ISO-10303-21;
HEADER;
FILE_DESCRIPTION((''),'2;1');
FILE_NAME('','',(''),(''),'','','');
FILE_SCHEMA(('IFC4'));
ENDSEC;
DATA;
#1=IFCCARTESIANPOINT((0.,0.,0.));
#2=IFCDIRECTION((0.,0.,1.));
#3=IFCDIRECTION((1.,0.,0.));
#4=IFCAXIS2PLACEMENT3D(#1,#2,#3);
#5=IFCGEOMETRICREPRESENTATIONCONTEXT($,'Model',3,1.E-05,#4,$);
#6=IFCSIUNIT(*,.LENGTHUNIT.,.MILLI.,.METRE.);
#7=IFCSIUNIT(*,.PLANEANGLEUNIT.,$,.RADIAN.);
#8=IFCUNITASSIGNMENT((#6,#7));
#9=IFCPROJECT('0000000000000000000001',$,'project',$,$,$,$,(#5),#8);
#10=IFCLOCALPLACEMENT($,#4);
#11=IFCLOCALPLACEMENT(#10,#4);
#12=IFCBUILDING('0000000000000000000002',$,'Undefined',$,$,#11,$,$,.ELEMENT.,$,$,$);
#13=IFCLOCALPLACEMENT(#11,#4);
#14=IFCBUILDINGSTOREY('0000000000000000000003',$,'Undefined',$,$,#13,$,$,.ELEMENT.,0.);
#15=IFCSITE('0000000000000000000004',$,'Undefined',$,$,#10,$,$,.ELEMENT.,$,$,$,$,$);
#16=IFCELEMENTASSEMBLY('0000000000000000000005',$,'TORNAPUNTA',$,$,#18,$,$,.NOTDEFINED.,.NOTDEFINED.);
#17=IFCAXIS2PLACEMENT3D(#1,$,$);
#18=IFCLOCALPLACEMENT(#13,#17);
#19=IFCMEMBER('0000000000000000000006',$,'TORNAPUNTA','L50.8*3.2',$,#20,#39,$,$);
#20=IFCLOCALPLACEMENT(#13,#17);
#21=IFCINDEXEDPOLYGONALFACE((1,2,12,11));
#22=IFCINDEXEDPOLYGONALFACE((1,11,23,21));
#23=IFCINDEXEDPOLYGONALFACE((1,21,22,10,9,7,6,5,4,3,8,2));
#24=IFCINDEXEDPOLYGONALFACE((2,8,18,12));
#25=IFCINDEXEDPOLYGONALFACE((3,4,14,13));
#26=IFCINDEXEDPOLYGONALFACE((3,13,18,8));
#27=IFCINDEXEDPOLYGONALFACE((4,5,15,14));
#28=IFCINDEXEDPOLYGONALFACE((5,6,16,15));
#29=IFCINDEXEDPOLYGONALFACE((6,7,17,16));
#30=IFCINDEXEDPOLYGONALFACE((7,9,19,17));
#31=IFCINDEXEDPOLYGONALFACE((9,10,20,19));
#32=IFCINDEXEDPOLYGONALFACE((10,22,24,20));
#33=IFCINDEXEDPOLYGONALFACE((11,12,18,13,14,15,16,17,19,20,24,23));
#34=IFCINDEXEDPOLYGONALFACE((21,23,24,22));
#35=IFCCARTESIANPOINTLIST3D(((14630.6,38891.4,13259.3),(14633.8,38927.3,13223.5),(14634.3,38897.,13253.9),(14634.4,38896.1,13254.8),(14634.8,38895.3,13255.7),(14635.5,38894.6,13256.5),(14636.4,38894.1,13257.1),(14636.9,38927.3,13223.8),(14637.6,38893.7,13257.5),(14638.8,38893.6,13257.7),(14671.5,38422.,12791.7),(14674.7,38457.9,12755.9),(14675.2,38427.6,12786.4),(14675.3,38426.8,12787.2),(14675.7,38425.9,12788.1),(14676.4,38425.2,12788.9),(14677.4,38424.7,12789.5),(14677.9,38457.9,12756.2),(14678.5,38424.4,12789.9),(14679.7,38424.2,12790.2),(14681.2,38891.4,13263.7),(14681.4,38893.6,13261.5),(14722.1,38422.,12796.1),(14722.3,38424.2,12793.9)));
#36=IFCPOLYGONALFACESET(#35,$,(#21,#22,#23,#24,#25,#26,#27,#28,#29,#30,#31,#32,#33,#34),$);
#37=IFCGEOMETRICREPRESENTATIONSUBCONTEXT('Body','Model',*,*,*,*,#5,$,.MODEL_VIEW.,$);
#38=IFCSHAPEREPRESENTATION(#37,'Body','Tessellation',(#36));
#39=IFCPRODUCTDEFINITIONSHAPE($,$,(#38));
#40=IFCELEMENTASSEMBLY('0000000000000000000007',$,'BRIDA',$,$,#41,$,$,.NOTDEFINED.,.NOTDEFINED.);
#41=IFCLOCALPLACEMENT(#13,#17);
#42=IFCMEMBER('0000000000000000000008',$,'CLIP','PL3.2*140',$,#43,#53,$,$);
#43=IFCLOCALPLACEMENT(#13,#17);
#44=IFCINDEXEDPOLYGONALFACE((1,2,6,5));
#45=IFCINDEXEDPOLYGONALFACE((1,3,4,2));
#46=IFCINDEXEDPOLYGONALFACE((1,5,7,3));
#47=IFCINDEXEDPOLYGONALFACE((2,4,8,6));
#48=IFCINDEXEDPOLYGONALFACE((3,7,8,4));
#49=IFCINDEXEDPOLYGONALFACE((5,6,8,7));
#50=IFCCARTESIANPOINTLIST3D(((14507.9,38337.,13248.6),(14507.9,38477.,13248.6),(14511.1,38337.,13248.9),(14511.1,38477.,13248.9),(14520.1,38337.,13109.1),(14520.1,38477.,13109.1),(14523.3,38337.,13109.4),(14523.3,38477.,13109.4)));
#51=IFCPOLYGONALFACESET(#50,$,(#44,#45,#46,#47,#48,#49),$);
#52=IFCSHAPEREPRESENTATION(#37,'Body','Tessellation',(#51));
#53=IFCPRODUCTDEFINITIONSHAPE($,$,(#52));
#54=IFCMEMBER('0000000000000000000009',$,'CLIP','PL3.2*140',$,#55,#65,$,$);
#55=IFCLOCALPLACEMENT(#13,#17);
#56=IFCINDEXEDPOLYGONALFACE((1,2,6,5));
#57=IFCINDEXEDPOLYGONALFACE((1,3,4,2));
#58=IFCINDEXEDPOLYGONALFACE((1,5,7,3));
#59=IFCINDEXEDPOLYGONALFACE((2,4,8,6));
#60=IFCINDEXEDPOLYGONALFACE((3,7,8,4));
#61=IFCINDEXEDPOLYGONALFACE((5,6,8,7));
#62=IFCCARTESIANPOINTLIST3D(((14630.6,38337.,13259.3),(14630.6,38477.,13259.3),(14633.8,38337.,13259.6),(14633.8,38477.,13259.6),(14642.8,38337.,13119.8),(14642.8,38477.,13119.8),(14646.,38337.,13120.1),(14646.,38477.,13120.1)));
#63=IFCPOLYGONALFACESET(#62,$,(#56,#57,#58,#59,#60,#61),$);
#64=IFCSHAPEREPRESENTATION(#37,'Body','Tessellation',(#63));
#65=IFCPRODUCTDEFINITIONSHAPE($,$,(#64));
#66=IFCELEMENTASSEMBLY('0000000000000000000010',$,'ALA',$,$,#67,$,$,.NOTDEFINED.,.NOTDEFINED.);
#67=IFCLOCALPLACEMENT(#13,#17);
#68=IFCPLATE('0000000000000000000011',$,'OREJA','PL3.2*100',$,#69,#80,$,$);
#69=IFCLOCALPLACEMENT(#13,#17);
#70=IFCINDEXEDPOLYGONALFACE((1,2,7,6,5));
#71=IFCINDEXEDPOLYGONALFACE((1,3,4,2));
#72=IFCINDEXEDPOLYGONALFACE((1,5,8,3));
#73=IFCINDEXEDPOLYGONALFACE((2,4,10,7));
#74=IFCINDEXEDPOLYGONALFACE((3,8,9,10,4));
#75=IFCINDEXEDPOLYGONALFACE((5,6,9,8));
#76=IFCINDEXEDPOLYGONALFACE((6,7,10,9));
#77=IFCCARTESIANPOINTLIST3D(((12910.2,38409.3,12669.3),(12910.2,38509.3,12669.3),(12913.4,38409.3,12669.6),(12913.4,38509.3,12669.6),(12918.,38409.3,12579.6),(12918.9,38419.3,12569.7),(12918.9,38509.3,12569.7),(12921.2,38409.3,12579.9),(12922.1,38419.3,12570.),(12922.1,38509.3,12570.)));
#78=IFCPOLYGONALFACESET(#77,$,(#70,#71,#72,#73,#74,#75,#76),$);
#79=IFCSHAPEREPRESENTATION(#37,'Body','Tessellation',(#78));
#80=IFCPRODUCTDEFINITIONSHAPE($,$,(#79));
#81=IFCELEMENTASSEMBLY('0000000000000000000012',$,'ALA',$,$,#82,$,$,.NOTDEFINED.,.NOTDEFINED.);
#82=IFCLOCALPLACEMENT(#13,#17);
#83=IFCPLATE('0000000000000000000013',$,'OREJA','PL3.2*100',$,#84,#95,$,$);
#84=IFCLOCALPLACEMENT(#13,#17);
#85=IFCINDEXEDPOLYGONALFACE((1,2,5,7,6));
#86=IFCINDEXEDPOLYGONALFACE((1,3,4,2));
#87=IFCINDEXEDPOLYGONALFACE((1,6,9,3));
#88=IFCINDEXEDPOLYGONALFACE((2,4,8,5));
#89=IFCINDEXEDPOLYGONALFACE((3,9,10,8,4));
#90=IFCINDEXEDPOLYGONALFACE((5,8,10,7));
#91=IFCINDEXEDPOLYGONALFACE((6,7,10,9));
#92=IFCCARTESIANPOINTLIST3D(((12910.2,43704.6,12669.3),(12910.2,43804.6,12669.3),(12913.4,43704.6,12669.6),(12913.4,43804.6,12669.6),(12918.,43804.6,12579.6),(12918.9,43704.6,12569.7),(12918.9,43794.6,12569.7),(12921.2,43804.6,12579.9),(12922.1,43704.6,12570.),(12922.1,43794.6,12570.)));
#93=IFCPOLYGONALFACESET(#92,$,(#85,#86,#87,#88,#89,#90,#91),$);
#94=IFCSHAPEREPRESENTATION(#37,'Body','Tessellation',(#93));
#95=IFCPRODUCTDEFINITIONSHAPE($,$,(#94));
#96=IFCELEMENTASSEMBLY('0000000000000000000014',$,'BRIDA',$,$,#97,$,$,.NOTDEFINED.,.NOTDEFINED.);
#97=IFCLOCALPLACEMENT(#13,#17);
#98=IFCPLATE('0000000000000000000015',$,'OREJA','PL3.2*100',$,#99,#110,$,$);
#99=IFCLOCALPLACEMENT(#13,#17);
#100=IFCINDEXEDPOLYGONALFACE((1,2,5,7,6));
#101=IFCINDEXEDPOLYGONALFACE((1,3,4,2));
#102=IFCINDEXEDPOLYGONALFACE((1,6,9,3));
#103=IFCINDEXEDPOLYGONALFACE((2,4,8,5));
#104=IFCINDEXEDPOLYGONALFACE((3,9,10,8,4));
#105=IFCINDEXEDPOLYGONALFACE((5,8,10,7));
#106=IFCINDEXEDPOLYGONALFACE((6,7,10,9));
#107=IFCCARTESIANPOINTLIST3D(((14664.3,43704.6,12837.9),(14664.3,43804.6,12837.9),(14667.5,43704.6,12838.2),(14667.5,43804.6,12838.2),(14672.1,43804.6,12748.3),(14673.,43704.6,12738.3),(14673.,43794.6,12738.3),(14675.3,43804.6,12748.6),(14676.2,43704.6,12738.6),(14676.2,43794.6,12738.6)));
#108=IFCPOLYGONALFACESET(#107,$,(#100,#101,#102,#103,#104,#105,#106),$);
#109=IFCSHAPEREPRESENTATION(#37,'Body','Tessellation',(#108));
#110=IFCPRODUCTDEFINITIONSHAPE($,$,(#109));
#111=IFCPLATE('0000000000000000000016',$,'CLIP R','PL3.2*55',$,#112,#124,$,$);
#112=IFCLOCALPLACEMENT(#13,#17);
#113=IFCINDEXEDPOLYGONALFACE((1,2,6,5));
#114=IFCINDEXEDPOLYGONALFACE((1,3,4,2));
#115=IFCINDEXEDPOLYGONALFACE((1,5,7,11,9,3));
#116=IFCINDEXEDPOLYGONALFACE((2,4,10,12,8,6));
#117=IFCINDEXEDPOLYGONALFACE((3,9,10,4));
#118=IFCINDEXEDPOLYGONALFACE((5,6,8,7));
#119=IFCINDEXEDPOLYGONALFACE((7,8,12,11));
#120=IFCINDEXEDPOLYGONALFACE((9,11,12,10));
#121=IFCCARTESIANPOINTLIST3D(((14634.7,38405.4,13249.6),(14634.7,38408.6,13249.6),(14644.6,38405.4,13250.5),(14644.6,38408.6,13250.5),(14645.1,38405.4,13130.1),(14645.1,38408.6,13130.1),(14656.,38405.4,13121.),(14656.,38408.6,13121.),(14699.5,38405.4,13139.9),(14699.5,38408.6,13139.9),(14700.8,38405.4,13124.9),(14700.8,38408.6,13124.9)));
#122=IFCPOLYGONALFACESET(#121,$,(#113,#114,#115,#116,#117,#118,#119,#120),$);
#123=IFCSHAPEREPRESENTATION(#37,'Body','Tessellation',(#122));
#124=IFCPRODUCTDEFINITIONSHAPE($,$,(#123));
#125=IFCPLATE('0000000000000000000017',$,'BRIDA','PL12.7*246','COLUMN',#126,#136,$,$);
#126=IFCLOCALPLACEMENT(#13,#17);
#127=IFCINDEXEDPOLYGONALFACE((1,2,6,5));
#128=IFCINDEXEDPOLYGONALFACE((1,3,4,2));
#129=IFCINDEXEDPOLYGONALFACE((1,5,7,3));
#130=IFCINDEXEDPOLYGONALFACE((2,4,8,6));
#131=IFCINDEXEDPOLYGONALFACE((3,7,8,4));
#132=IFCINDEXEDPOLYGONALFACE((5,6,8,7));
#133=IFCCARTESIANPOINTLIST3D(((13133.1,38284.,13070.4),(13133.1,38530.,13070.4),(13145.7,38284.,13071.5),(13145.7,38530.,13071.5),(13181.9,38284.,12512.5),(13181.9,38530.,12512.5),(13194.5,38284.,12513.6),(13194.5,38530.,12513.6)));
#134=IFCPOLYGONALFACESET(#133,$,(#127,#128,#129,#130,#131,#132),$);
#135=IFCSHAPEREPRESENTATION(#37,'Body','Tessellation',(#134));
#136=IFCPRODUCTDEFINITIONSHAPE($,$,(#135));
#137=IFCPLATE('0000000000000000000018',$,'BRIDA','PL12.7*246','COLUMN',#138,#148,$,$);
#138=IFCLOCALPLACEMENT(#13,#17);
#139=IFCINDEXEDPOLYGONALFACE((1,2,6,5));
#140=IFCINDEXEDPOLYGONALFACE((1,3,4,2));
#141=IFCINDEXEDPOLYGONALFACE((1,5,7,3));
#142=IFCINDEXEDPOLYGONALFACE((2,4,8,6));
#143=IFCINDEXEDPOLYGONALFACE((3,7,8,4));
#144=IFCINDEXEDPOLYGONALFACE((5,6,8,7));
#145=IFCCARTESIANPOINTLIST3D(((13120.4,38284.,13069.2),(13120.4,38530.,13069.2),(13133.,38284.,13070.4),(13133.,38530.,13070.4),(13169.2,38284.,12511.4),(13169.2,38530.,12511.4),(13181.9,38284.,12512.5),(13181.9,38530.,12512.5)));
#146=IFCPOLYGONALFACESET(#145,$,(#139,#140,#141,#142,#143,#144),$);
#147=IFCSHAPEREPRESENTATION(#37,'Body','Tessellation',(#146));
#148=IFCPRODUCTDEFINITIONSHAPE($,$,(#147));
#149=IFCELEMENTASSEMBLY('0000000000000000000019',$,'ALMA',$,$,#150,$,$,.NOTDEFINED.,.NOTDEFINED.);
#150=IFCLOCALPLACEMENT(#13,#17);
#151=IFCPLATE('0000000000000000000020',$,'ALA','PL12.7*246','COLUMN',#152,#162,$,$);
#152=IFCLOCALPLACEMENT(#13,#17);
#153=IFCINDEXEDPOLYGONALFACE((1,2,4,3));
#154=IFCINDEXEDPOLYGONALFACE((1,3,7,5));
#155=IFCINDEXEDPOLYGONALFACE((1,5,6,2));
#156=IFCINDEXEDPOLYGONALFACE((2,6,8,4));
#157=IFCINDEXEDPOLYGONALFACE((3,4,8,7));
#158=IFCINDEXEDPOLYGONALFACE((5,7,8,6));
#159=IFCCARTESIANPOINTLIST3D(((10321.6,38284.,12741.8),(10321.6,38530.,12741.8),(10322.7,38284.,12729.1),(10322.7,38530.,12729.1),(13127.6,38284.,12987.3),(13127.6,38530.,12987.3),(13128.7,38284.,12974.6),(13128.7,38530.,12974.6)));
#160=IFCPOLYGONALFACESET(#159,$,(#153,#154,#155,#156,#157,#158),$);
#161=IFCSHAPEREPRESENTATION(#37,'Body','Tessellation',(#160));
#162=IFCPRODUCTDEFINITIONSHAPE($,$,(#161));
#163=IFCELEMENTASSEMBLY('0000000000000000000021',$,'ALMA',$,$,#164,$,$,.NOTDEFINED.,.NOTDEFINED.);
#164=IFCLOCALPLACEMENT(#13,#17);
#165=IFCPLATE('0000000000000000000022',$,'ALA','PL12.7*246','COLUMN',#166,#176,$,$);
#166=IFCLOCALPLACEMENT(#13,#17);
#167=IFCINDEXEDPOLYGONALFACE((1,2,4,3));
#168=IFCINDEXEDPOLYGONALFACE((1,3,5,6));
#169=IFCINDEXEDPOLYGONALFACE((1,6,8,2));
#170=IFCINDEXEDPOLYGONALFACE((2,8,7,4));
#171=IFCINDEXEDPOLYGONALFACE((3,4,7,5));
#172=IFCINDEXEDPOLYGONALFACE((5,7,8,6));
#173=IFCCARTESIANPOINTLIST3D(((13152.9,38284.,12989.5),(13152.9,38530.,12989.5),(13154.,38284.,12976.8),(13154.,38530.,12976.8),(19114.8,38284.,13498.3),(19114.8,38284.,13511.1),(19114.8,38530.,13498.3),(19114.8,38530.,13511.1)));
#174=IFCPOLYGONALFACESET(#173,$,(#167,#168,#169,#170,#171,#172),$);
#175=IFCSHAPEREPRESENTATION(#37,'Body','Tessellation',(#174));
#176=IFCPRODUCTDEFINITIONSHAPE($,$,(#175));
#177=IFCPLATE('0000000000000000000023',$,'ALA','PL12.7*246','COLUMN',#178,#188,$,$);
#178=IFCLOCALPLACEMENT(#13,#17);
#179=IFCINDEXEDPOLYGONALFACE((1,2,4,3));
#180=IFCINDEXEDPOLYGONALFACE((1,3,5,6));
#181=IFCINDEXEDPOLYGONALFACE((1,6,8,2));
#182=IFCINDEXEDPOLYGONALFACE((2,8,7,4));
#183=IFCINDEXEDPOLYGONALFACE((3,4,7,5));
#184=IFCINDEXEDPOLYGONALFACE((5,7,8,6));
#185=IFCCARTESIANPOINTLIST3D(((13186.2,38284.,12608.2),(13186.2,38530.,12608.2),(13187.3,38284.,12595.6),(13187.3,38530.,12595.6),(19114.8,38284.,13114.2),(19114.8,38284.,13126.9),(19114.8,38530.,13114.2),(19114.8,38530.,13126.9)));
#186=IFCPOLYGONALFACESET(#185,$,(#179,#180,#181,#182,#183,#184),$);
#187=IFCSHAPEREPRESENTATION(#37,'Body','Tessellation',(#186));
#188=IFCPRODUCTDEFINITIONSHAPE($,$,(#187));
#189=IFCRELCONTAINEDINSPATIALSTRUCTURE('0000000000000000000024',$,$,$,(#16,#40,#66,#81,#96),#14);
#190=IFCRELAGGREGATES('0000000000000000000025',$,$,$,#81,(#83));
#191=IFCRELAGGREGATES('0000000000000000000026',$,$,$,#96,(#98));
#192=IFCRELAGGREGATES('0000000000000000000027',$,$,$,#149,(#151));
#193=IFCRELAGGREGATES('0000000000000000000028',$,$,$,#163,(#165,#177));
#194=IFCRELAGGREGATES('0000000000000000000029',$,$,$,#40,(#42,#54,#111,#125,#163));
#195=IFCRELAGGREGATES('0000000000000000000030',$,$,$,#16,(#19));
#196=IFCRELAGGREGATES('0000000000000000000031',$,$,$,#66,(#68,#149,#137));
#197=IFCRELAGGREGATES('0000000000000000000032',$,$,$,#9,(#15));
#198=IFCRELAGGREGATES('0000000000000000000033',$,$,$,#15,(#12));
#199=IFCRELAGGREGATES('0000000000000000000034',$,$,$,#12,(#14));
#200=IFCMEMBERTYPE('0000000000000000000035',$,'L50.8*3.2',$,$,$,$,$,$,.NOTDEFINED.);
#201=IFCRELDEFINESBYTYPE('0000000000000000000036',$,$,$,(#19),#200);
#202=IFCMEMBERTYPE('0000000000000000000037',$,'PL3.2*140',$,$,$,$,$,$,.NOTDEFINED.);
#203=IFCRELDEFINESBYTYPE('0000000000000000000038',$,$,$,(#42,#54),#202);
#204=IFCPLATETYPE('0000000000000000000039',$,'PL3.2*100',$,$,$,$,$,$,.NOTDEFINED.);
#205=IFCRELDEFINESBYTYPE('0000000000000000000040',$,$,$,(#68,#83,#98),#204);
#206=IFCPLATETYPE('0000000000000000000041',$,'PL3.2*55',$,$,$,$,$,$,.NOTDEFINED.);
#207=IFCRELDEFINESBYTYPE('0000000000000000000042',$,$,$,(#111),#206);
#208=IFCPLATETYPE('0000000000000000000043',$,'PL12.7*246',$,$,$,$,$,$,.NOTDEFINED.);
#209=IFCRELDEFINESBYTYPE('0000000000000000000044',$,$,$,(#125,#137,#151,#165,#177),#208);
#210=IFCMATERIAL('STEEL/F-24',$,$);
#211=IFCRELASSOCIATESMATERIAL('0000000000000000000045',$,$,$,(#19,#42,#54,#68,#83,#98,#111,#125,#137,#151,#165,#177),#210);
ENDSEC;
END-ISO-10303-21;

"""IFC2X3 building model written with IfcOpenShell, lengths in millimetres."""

from ifc_helpers import new_model, si_unit, frame, origin_with_axes, origin_2d_with_axis, place, context, subcontext, project, spatial, polyline, rectangle, l_section, outline, extrude, clip, halfspace, material, type_object, element, aggregate, save


model = new_model("IFC2X3")

# Units and contexts
model_context = context("Model", 3, precision=1e-05, world=origin_with_axes())
body_context = subcontext(model_context, "Body", "Model", "MODEL_VIEW")
ifc_project = project(units=[si_unit("LENGTHUNIT", "METRE", prefix="MILLI"), si_unit("PLANEANGLEUNIT", "RADIAN")], contexts=[model_context])

# Site, building, storey
site_placement = place(None, origin_with_axes())
site = spatial("IfcSite", under=ifc_project, at=site_placement, Name="Undefined", CompositionType="ELEMENT")
building_placement = place(site_placement, origin_with_axes())
building = spatial("IfcBuilding", under=site, at=building_placement, Name="Undefined", CompositionType="ELEMENT")
storey_placement = place(building_placement, origin_with_axes())
storey = spatial("IfcBuildingStorey", under=building, at=storey_placement, Name="Undefined", CompositionType="ELEMENT", Elevation=0.0)

# Element assembly, member
assembly_1_placement = place(storey_placement, origin_with_axes())
assembly_1 = element("IfcElementAssembly", 1, at=assembly_1_placement, inside=storey, Name="TORNAPUNTA", AssemblyPlace="NOTDEFINED", PredefinedType="NOTDEFINED")
ifc_material_1 = material(Name="STEEL/F-24")
member_type_1 = type_object("IfcMemberType", Name="L50.8*3.2", PredefinedType="NOTDEFINED")
member_1_placement = place(assembly_1_placement, frame((14657.5, 38909.3, 13243.6), z_axis=(0.061628, 0.707107, -0.704416), x_axis=(0.061628, -0.707107, -0.704416)))
member_1 = element("IfcMember", 2, at=member_1_placement, type_object=member_type_1, material=ifc_material_1, Name="TORNAPUNTA", Description="L50.8*3.2", context=body_context, shape_type="SweptSolid", body=[
    extrude(l_section(Depth=50.8, Width=50.8, Thickness=3.2, FilletRadius=4.8, at=origin_2d_with_axis()), frame((663.8, 0.0, 0.0), z_axis=(-1.0, 0.0, 0.0), x_axis=(0.0, -1.0, 0.0)), (0.0, 0.0, 1.0), 663.8),
])

# Element assembly, members
assembly_2_placement = place(storey_placement, origin_with_axes())
assembly_2 = element("IfcElementAssembly", 3, at=assembly_2_placement, inside=storey, Name="BRIDA", AssemblyPlace="NOTDEFINED", PredefinedType="NOTDEFINED")
member_type_2 = type_object("IfcMemberType", Name="PL3.2*140", PredefinedType="NOTDEFINED")
member_2_placement = place(assembly_2_placement, frame((14509.5, 38407.0, 13248.7), z_axis=(0.0, -1.0, 0.0), x_axis=(0.087155, 0.0, -0.996195)))
member_2 = element("IfcMember", 4, at=member_2_placement, type_object=member_type_2, material=ifc_material_1, Name="CLIP", Description="PL3.2*140", context=body_context, shape_type="SweptSolid", body=[
    extrude(rectangle(XDim=3.2, YDim=140.0, at=origin_2d_with_axis()), frame((140.0, 0.0, 0.0), z_axis=(-1.0, 0.0, 0.0), x_axis=(0.0, -1.0, 0.0)), (0.0, 0.0, 1.0), 140.0),
])
member_3_placement = place(assembly_2_placement, frame((14632.2, 38407.0, 13259.5), z_axis=(0.0, -1.0, 0.0), x_axis=(0.087155, 0.0, -0.996195)))
member_3 = element("IfcMember", 5, at=member_3_placement, type_object=member_type_2, material=ifc_material_1, Name="CLIP", Description="PL3.2*140", context=body_context, shape_type="SweptSolid", body=[
    extrude(rectangle(XDim=3.2, YDim=140.0, at=origin_2d_with_axis()), frame((140.0, 0.0, 0.0), z_axis=(-1.0, 0.0, 0.0), x_axis=(0.0, -1.0, 0.0)), (0.0, 0.0, 1.0), 140.0),
])

# Element assemblies, plates
assembly_3_placement = place(storey_placement, origin_with_axes())
assembly_3 = element("IfcElementAssembly", 6, at=assembly_3_placement, inside=storey, Name="ALA", AssemblyPlace="NOTDEFINED", PredefinedType="NOTDEFINED")
plate_type_1 = type_object("IfcPlateType", Name="PL3.2*100", PredefinedType="NOTDEFINED")
plate_1_placement = place(assembly_3_placement, frame((12920.5, 38509.3, 12569.8), z_axis=(-0.996195, 0.0, -0.087155), x_axis=(0.0, -1.0, 0.0)))
plate_1 = element("IfcPlate", 7, at=plate_1_placement, type_object=plate_type_1, material=ifc_material_1, Name="OREJA", Description="PL3.2*100", context=body_context, shape_type="SweptSolid", body=[
    extrude(outline(polyline([(0.0, 0.0), (90.0, 0.0), (100.0, 10.0), (100.0, 100.0), (0.0, 100.0), (0.0, 0.0)])), frame((0.0, 0.0, -1.6), z_axis=(0.0, 0.0, 1.0), x_axis=(1.0, 0.0, 0.0)), (0.0, 0.0, 1.0), 3.2),
])
assembly_4_placement = place(storey_placement, origin_with_axes())
assembly_4 = element("IfcElementAssembly", 8, at=assembly_4_placement, inside=storey, Name="ALA", AssemblyPlace="NOTDEFINED", PredefinedType="NOTDEFINED")
plate_2_placement = place(assembly_4_placement, frame((12920.5, 43704.6, 12569.8), z_axis=(0.996195, 0.0, 0.087155), x_axis=(0.0, 1.0, 0.0)))
plate_2 = element("IfcPlate", 9, at=plate_2_placement, type_object=plate_type_1, material=ifc_material_1, Name="OREJA", Description="PL3.2*100", context=body_context, shape_type="SweptSolid", body=[
    extrude(outline(polyline([(0.0, 0.0), (90.0, 0.0), (100.0, 10.0), (100.0, 100.0), (0.0, 100.0), (0.0, 0.0)])), frame((0.0, 0.0, -1.6), z_axis=(0.0, 0.0, 1.0), x_axis=(1.0, 0.0, 0.0)), (0.0, 0.0, 1.0), 3.2),
])
aggregate(assembly_4, [plate_2])
assembly_5_placement = place(storey_placement, origin_with_axes())
assembly_5 = element("IfcElementAssembly", 10, at=assembly_5_placement, inside=storey, Name="BRIDA", AssemblyPlace="NOTDEFINED", PredefinedType="NOTDEFINED")
plate_3_placement = place(assembly_5_placement, frame((14674.6, 43704.6, 12738.5), z_axis=(0.996195, 0.0, 0.087155), x_axis=(0.0, 1.0, 0.0)))
plate_3 = element("IfcPlate", 11, at=plate_3_placement, type_object=plate_type_1, material=ifc_material_1, Name="OREJA", Description="PL3.2*100", context=body_context, shape_type="SweptSolid", body=[
    extrude(outline(polyline([(0.0, 0.0), (90.0, 0.0), (100.0, 10.0), (100.0, 100.0), (0.0, 100.0), (0.0, 0.0)])), frame((0.0, 0.0, -1.6), z_axis=(0.0, 0.0, 1.0), x_axis=(1.0, 0.0, 0.0)), (0.0, 0.0, 1.0), 3.2),
])
aggregate(assembly_5, [plate_3])

# Plates
plate_type_2 = type_object("IfcPlateType", Name="PL3.2*55", PredefinedType="NOTDEFINED")
plate_4_placement = place(assembly_2_placement, frame((14634.7, 38407.0, 13249.6), z_axis=(0.0, 1.0, 0.0), x_axis=(0.996195, 0.0, 0.087155)))
plate_4 = element("IfcPlate", 12, at=plate_4_placement, type_object=plate_type_2, material=ifc_material_1, Name="CLIP R", Description="PL3.2*55", context=body_context, shape_type="SweptSolid", body=[
    extrude(outline(polyline([(0.0, 0.0), (10.0, 0.0), (55.0, 115.0), (55.0, 130.0), (10.0, 130.0), (0.0, 120.0), (0.0, 0.0)])), frame((0.0, 0.0, -1.6), z_axis=(0.0, 0.0, 1.0), x_axis=(1.0, 0.0, 0.0)), (0.0, 0.0, 1.0), 3.2),
])
plate_type_3 = type_object("IfcPlateType", Name="PL12.7*246", PredefinedType="NOTDEFINED")
plate_5_placement = place(assembly_2_placement, frame((13139.4, 38407.0, 13070.9), z_axis=(-0.996195, 0.0, -0.087155), x_axis=(0.087155, 0.0, -0.996195)))
plate_5 = element("IfcPlate", 13, at=plate_5_placement, type_object=plate_type_3, material=ifc_material_1, Name="BRIDA", Description="PL12.7*246", ObjectType="COLUMN", context=body_context, shape_type="SweptSolid", body=[
    extrude(outline(polyline([(0.0, -123.0), (0.0, 123.0), (560.0, 123.0), (560.0, -123.0), (0.0, -123.0)])), frame((0.0, 0.0, -6.3), z_axis=(0.0, 0.0, 1.0), x_axis=(1.0, 0.0, 0.0)), (0.0, 0.0, 1.0), 12.7),
])
plate_6_placement = place(assembly_3_placement, frame((13126.7, 38407.0, 13069.8), z_axis=(-0.996195, 0.0, -0.087155), x_axis=(0.087155, 0.0, -0.996195)))
plate_6 = element("IfcPlate", 14, at=plate_6_placement, type_object=plate_type_3, material=ifc_material_1, Name="BRIDA", Description="PL12.7*246", ObjectType="COLUMN", context=body_context, shape_type="SweptSolid", body=[
    extrude(outline(polyline([(0.0, -123.0), (0.0, 123.0), (560.0, 123.0), (560.0, -123.0), (0.0, -123.0)])), frame((0.0, 0.0, -6.3), z_axis=(0.0, 0.0, 1.0), x_axis=(1.0, 0.0, 0.0)), (0.0, 0.0, 1.0), 12.7),
])

# Element assemblies, plates
assembly_6_placement = place(assembly_3_placement, origin_with_axes())
assembly_6 = element("IfcElementAssembly", 15, at=assembly_6_placement, Name="ALMA", AssemblyPlace="NOTDEFINED", PredefinedType="NOTDEFINED")
plate_7_placement = place(assembly_6_placement, frame((13128.1, 38407.0, 12980.9), z_axis=(-0.087156, 0.0, 0.996195), x_axis=(-0.996195, 0.0, -0.087155)))
plate_7 = element("IfcPlate", 16, at=plate_7_placement, type_object=plate_type_3, material=ifc_material_1, Name="ALA", Description="PL12.7*246", ObjectType="COLUMN", context=body_context, shape_type="Clipping", body=[
    clip(extrude(outline(polyline([(0.0, -123.0), (0.0, 123.0), (2816.7, 123.0), (2816.7, -123.0), (0.0, -123.0)])), frame((0.0, 0.0, -6.3), z_axis=(0.0, 0.0, 1.0), x_axis=(1.0, 0.0, 0.0)), (0.0, 0.0, 1.0), 12.7), halfspace(frame((0.0, 0.0, 0.0), z_axis=(1.0, 0.0, 0.0), x_axis=(0.0, -1.0, 0.0)), True)),
])
aggregate(assembly_6, [plate_7])
assembly_7_placement = place(assembly_2_placement, origin_with_axes())
assembly_7 = element("IfcElementAssembly", 17, at=assembly_7_placement, Name="ALMA", AssemblyPlace="NOTDEFINED", PredefinedType="NOTDEFINED")
plate_8_placement = place(assembly_7_placement, frame((13153.4, 38407.0, 12983.2), z_axis=(0.087155, 0.0, -0.996195), x_axis=(0.996195, 0.0, 0.087155)))
plate_8 = element("IfcPlate", 18, at=plate_8_placement, type_object=plate_type_3, material=ifc_material_1, Name="ALA", Description="PL12.7*246", ObjectType="COLUMN", context=body_context, shape_type="Clipping", body=[
    clip(clip(extrude(outline(polyline([(0.1, -123.0), (0.1, 123.0), (5984.8, 123.0), (5984.8, -123.0), (0.1, -123.0)])), frame((0.0, 0.0, -6.3), z_axis=(0.0, 0.0, 1.0), x_axis=(1.0, 0.0, 0.0)), (0.0, 0.0, 1.0), 12.7), halfspace(frame((5984.8, 0.0, -6.4), z_axis=(-0.996195, 0.0, -0.087155), x_axis=(0.0, 1.0, 0.0)), True)), halfspace(frame((0.1, 0.0, 0.0), z_axis=(-1.0, 0.0, 0.0), x_axis=(0.0, 1.0, 0.0)), False)),
])
plate_9_placement = place(assembly_7_placement, frame((13186.7, 38407.0, 12601.9), z_axis=(0.087155, 0.0, -0.996195), x_axis=(0.996195, 0.0, 0.087155)))
plate_9 = element("IfcPlate", 19, at=plate_9_placement, type_object=plate_type_3, material=ifc_material_1, Name="ALA", Description="PL12.7*246", ObjectType="COLUMN", context=body_context, shape_type="Clipping", body=[
    clip(clip(extrude(outline(polyline([(0.1, -123.0), (0.1, 123.0), (5951.3, 123.0), (5951.3, -123.0), (0.1, -123.0)])), frame((0.0, 0.0, -6.3), z_axis=(0.0, 0.0, 1.0), x_axis=(1.0, 0.0, 0.0)), (0.0, 0.0, 1.0), 12.7), halfspace(frame((5951.3, 0.0, -6.4), z_axis=(-0.996195, 0.0, -0.087155), x_axis=(0.0, 1.0, 0.0)), True)), halfspace(frame((0.1, 0.0, 0.0), z_axis=(1.0, 0.0, 0.0), x_axis=(0.0, -1.0, 0.0)), True)),
])
aggregate(assembly_7, [plate_8, plate_9])

aggregate(assembly_2, [member_2, member_3, plate_4, plate_5, assembly_7])

aggregate(assembly_1, [member_1])

aggregate(assembly_3, [plate_1, assembly_6, plate_6])

save(model, "model.ifc")
